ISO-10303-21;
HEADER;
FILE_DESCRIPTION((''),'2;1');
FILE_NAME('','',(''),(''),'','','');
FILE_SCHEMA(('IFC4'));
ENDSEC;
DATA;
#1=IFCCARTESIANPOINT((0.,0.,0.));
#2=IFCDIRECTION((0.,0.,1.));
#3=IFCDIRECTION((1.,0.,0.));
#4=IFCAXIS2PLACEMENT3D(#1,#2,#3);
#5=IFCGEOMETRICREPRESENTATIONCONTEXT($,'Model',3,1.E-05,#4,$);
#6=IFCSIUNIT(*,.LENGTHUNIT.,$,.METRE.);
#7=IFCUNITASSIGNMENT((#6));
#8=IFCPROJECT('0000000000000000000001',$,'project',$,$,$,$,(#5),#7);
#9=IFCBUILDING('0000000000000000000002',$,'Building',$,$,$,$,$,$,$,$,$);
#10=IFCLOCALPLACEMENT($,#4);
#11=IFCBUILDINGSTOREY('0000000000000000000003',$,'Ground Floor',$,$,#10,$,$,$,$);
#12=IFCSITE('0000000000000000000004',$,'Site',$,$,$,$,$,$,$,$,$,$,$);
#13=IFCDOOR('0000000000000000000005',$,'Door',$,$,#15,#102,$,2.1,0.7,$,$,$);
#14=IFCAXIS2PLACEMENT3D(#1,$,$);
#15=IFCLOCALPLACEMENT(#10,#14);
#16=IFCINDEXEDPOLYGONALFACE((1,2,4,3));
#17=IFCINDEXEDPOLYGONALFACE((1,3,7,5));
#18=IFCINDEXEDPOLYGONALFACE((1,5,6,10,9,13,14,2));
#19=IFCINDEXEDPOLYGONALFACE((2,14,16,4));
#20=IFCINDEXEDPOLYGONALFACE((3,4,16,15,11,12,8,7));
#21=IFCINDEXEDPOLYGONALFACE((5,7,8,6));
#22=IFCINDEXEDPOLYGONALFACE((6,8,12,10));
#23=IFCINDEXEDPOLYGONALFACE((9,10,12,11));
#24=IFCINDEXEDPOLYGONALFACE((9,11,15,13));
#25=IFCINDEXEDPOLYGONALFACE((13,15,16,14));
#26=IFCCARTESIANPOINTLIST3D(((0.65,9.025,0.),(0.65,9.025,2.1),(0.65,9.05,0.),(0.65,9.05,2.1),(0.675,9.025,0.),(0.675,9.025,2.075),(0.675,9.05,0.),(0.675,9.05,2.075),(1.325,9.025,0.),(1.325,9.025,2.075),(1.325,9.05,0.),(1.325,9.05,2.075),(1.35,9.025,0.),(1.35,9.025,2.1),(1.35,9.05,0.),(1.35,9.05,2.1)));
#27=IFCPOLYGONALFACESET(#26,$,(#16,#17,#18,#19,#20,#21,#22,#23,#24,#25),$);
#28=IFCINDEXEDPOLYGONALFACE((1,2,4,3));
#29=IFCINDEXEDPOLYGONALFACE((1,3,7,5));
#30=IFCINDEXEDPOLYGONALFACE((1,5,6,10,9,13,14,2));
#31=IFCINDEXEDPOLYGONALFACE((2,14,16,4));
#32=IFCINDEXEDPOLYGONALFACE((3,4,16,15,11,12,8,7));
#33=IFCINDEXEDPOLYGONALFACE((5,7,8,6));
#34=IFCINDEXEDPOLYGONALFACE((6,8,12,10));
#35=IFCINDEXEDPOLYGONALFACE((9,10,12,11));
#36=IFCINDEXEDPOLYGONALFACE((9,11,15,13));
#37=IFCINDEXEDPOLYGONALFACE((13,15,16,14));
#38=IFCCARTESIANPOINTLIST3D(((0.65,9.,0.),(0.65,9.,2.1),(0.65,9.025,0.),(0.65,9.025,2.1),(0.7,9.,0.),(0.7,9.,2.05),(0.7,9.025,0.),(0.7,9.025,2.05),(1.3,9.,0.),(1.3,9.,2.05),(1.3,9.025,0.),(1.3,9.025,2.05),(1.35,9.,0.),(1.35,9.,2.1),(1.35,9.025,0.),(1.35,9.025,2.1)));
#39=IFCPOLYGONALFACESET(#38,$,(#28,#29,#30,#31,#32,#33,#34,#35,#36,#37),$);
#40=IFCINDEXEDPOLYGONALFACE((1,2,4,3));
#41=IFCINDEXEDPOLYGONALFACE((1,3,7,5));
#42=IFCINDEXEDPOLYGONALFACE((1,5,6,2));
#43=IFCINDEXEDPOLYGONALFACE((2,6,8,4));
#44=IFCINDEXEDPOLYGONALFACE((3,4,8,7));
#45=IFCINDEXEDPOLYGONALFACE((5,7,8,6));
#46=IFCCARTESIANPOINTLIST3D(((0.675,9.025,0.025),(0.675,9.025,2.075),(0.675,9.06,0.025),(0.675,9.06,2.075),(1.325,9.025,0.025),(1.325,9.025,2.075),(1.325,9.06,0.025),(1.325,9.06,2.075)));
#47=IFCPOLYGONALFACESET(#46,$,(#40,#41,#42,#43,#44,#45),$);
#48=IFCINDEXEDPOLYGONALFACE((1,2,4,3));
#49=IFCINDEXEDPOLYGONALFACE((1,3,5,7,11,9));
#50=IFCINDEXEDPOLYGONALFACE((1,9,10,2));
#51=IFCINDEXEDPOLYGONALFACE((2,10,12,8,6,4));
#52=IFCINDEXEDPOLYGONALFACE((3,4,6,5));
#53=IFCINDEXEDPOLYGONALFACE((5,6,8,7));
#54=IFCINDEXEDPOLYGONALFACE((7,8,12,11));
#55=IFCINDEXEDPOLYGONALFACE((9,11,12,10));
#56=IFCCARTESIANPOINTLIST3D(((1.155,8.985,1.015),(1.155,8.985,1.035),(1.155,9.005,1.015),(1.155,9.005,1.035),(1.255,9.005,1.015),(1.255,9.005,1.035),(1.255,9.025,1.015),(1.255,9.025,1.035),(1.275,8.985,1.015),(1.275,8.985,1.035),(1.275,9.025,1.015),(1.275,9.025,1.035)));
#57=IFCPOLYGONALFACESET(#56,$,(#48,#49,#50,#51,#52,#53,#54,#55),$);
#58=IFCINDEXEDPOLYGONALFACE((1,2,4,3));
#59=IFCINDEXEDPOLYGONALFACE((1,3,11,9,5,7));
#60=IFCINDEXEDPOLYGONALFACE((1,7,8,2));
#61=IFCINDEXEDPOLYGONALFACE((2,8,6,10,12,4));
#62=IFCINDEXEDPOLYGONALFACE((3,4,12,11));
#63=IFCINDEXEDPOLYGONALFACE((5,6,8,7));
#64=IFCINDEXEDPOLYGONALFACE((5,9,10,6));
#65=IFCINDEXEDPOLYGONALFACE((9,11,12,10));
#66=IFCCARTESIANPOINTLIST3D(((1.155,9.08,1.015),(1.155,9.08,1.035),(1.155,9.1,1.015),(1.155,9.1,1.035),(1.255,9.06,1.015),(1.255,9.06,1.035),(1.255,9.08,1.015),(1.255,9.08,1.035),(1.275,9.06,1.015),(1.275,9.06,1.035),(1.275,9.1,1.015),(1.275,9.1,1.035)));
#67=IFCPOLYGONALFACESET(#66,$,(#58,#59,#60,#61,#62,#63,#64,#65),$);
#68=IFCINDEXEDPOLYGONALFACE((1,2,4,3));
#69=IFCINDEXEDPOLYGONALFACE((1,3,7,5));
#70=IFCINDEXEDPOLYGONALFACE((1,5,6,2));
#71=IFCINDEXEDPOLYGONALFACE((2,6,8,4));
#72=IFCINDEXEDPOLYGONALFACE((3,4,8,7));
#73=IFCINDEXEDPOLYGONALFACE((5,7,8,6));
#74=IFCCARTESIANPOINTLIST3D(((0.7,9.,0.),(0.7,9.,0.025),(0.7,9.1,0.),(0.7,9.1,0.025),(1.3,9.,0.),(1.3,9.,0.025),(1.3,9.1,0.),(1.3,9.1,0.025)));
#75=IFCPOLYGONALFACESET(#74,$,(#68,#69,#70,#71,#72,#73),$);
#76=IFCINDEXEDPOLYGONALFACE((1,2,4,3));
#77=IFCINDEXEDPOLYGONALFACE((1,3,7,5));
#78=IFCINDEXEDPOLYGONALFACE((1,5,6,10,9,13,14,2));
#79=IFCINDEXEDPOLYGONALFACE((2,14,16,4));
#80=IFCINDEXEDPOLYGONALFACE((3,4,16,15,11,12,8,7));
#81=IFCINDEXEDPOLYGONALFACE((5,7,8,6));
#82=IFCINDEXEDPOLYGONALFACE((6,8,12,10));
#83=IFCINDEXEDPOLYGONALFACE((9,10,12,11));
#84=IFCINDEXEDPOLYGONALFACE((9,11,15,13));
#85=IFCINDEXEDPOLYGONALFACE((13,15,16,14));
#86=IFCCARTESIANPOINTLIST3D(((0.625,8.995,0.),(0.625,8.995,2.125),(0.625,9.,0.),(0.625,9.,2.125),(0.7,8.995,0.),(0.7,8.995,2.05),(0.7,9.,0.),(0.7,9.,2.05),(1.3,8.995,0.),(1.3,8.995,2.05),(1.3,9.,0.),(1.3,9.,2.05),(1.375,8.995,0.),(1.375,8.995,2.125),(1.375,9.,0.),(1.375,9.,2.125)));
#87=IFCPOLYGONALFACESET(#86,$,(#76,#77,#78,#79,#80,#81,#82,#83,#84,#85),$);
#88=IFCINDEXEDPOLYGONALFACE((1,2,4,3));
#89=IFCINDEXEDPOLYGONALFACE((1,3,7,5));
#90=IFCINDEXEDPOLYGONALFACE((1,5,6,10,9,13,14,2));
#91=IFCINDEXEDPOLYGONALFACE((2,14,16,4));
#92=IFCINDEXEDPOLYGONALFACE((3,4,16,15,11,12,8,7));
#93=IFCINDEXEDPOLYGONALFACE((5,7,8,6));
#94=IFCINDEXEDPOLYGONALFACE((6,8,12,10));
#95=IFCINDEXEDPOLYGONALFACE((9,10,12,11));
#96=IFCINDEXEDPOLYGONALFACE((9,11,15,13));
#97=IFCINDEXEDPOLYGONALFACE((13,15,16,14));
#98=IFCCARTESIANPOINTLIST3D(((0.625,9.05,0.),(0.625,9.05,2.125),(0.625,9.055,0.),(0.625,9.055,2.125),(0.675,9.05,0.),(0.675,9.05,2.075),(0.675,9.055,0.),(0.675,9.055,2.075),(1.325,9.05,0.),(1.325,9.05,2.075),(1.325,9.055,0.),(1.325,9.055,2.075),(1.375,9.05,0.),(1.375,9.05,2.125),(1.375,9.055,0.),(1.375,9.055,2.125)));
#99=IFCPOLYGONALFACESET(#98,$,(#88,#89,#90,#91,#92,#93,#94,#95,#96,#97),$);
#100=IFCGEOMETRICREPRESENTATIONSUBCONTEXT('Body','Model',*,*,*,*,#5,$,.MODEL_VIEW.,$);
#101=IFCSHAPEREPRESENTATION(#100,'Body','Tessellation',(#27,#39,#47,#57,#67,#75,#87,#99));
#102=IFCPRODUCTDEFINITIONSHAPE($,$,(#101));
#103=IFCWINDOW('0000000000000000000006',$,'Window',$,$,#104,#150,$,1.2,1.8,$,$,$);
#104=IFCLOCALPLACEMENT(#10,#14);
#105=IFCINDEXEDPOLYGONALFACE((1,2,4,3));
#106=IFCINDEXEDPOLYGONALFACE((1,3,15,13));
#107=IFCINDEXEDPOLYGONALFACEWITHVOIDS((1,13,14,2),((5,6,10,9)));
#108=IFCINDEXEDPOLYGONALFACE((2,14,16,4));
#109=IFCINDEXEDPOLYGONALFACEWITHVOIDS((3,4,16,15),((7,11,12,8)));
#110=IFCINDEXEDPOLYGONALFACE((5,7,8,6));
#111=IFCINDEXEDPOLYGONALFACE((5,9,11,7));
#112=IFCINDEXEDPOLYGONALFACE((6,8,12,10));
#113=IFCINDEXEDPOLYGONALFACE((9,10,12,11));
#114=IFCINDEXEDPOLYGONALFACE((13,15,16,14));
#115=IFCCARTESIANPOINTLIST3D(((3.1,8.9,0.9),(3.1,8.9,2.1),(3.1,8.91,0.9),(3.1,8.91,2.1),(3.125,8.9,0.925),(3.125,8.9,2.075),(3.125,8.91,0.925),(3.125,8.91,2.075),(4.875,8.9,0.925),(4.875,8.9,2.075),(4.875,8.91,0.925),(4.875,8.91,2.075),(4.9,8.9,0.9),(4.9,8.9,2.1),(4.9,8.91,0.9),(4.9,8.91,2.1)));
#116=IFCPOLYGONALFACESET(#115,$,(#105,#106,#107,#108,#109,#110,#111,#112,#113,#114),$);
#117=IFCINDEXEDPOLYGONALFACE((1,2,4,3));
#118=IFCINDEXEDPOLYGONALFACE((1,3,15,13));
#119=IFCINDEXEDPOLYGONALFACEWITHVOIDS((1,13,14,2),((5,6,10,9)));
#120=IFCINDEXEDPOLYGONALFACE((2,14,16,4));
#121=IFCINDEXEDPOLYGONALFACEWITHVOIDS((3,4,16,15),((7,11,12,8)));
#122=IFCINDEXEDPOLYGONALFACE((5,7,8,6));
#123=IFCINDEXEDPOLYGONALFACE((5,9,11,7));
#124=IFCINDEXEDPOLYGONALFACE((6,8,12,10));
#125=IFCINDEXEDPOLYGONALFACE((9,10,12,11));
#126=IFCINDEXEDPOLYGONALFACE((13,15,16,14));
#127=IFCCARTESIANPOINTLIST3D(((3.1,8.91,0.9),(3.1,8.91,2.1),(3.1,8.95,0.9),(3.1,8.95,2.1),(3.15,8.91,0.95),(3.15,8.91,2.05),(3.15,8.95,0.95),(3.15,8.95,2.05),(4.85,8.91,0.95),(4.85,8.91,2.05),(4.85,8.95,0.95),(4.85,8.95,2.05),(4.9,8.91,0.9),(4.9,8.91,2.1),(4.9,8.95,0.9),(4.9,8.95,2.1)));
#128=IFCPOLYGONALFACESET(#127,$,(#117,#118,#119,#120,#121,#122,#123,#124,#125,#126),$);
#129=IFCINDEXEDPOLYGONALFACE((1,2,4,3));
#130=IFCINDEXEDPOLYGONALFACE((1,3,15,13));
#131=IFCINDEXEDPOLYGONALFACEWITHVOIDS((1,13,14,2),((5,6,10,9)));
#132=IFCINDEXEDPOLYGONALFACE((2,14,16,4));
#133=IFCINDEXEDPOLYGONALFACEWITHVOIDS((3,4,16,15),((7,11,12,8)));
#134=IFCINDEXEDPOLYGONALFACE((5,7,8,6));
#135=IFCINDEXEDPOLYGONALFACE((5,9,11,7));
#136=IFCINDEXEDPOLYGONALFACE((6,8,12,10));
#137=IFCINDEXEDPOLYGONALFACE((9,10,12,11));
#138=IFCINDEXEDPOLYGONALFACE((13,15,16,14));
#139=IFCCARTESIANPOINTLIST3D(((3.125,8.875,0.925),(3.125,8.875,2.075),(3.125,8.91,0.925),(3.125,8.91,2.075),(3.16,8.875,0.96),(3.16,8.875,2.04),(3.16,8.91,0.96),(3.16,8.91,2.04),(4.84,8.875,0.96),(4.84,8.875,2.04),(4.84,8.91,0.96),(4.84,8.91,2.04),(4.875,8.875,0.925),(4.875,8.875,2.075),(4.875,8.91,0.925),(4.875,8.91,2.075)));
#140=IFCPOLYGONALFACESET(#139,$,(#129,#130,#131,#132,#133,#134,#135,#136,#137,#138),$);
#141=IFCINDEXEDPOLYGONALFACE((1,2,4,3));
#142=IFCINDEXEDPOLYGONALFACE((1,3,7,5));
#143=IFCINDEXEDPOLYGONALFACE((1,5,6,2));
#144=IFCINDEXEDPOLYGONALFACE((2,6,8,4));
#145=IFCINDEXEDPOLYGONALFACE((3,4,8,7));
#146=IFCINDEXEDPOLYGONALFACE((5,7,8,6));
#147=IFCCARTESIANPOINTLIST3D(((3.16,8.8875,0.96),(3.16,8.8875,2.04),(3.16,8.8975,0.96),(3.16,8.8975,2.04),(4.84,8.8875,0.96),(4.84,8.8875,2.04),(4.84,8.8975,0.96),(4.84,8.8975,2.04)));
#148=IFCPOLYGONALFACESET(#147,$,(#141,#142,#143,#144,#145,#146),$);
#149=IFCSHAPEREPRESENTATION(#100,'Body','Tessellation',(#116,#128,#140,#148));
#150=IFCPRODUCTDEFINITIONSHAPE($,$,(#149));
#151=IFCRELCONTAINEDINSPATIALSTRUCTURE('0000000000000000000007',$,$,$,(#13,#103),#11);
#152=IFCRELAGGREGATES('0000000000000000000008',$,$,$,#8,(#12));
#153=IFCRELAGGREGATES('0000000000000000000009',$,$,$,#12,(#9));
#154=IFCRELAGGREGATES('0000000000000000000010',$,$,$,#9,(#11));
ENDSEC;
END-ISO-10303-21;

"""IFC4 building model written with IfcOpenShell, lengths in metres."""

from ifc_helpers import new_model, si_unit, frame, origin_with_axes, place, context, subcontext, project, spatial, line, indexed_curve, outline, extrude, element, save


model = new_model("IFC4")

# Units and contexts
model_context = context("Model", 3, precision=1e-05, world=origin_with_axes())
body_context = subcontext(model_context, "Body", "Model", "MODEL_VIEW")
ifc_project = project(units=[si_unit("LENGTHUNIT", "METRE")], contexts=[model_context])

# Site, building, storey
site = spatial("IfcSite", under=ifc_project, Name="Site")
building = spatial("IfcBuilding", under=site, Name="Building")
storey_placement = place(None, origin_with_axes())
storey = spatial("IfcBuildingStorey", under=building, at=storey_placement, Name="Ground Floor")

# Door
door_1_placement = place(storey_placement, frame((0.65, 9.0, 0.0), z_axis=(0.0, 0.0, 1.0), x_axis=(1.0, 0.0, 0.0)))
element("IfcDoor", 1, at=door_1_placement, inside=storey, Name="Door", OverallHeight=2.1, OverallWidth=0.7, context=body_context, shape_type="SweptSolid", body=[
    extrude(outline(indexed_curve([(0.0, 0.0), (0.0, 2.1), (0.7, 2.1), (0.7, 0.0), (0.675, 0.0), (0.675, 2.075), (0.025, 2.075), (0.025, 0.0)], segments=[line(1, 2, 3, 4, 5, 6, 7, 8, 1)])), frame((0.0, 0.025, 0.0), z_axis=(0.0, -1.0, 0.0), x_axis=(1.0, 0.0, 0.0)), (0.0, 0.0, -1.0), 0.025),
    extrude(outline(indexed_curve([(0.0, 0.0), (0.0, 2.1), (0.7, 2.1), (0.7, 0.0), (0.65, 0.0), (0.65, 2.05), (0.05, 2.05), (0.05, 0.0)], segments=[line(1, 2, 3, 4, 5, 6, 7, 8, 1)])), frame((0.0, 0.0, 0.0), z_axis=(0.0, -1.0, 0.0), x_axis=(1.0, 0.0, 0.0)), (0.0, 0.0, -1.0), 0.025),
    extrude(outline(indexed_curve([(0.0, 0.0), (0.65, 0.0), (0.65, 0.035), (0.0, 0.035)], segments=[line(1, 2, 3, 4, 1)])), frame((0.025, 0.025, 0.025), z_axis=(0.0, 0.0, 1.0), x_axis=(1.0, 0.0, 0.0)), (0.0, 0.0, 1.0), 2.05),
    extrude(outline(indexed_curve([(0.0, 0.0), (0.0, -0.04), (-0.12, -0.04), (-0.12, -0.02), (-0.02, -0.02), (-0.02, 0.0)], segments=[line(1, 2, 3, 4, 5, 6, 1)])), frame((0.625, 0.025, 1.015), z_axis=(0.0, 0.0, 1.0), x_axis=(1.0, 0.0, 0.0)), (0.0, 0.0, 1.0), 0.02),
    extrude(outline(indexed_curve([(0.0, 0.0), (0.0, 0.04), (-0.12, 0.04), (-0.12, 0.02), (-0.02, 0.02), (-0.02, 0.0)], segments=[line(1, 2, 3, 4, 5, 6, 1)])), frame((0.625, 0.06, 1.015), z_axis=(0.0, 0.0, 1.0), x_axis=(1.0, 0.0, 0.0)), (0.0, 0.0, 1.0), 0.02),
    extrude(outline(indexed_curve([(0.0, 0.0), (0.6, 0.0), (0.6, 0.1), (0.0, 0.1)], segments=[line(1, 2, 3, 4, 1)])), frame((0.05, 0.0, 0.0), z_axis=(0.0, 0.0, 1.0), x_axis=(1.0, 0.0, 0.0)), (0.0, 0.0, 1.0), 0.025),
    extrude(outline(indexed_curve([(0.0, 0.0), (0.0, 2.125), (0.75, 2.125), (0.75, 0.0), (0.675, 0.0), (0.675, 2.05), (0.075, 2.05), (0.075, 0.0)], segments=[line(1, 2, 3, 4, 5, 6, 7, 8, 1)])), frame((-0.025, -0.005, 0.0), z_axis=(0.0, -1.0, 0.0), x_axis=(1.0, 0.0, 0.0)), (0.0, 0.0, -1.0), 0.005),
    extrude(outline(indexed_curve([(0.0, 0.0), (0.0, 2.125), (0.75, 2.125), (0.75, 0.0), (0.7, 0.0), (0.7, 2.075), (0.05, 2.075), (0.05, 0.0)], segments=[line(1, 2, 3, 4, 5, 6, 7, 8, 1)])), frame((-0.025, 0.05, 0.0), z_axis=(0.0, -1.0, 0.0), x_axis=(1.0, 0.0, 0.0)), (0.0, 0.0, -1.0), 0.005),
])

# Window
window_placement = place(storey_placement, frame((4.9, 9.0, 0.9), z_axis=(0.0, 0.0, 1.0), x_axis=(-1.0, 0.0, 0.0)))
element("IfcWindow", 2, at=window_placement, inside=storey, Name="Window", OverallHeight=1.2, OverallWidth=1.8, context=body_context, shape_type="SweptSolid", body=[
    extrude(outline(indexed_curve([(0.0, 0.0), (1.8, 0.0), (1.8, 1.2), (0.0, 1.2)], segments=[line(1, 2, 3, 4, 1)]), holes=[indexed_curve([(0.025, 0.025), (1.775, 0.025), (1.775, 1.175), (0.025, 1.175)], segments=[line(1, 2, 3, 4, 1)])]), frame((0.0, 0.09, 0.0), z_axis=(0.0, -1.0, 0.0), x_axis=(1.0, 0.0, 0.0)), (0.0, 0.0, -1.0), 0.01),
    extrude(outline(indexed_curve([(0.0, 0.0), (1.8, 0.0), (1.8, 1.2), (0.0, 1.2)], segments=[line(1, 2, 3, 4, 1)]), holes=[indexed_curve([(0.05, 0.05), (1.75, 0.05), (1.75, 1.15), (0.05, 1.15)], segments=[line(1, 2, 3, 4, 1)])]), frame((0.0, 0.05, 0.0), z_axis=(0.0, -1.0, 0.0), x_axis=(1.0, 0.0, 0.0)), (0.0, 0.0, -1.0), 0.04),
    extrude(outline(indexed_curve([(0.0, 0.0), (1.75, 0.0), (1.75, 1.15), (0.0, 1.15)], segments=[line(1, 2, 3, 4, 1)]), holes=[indexed_curve([(0.035, 0.035), (1.715, 0.035), (1.715, 1.115), (0.035, 1.115)], segments=[line(1, 2, 3, 4, 1)])]), frame((0.025, 0.09, 0.025), z_axis=(0.0, -1.0, 0.0), x_axis=(1.0, 0.0, 0.0)), (0.0, 0.0, -1.0), 0.035),
    extrude(outline(indexed_curve([(0.035, 0.035), (1.715, 0.035), (1.715, 1.115), (0.035, 1.115)], segments=[line(1, 2, 3, 4, 1)])), frame((0.025, 0.1025, 0.025), z_axis=(0.0, -1.0, 0.0), x_axis=(1.0, 0.0, 0.0)), (0.0, 0.0, -1.0), 0.01),
])

save(model, "model.ifc")
